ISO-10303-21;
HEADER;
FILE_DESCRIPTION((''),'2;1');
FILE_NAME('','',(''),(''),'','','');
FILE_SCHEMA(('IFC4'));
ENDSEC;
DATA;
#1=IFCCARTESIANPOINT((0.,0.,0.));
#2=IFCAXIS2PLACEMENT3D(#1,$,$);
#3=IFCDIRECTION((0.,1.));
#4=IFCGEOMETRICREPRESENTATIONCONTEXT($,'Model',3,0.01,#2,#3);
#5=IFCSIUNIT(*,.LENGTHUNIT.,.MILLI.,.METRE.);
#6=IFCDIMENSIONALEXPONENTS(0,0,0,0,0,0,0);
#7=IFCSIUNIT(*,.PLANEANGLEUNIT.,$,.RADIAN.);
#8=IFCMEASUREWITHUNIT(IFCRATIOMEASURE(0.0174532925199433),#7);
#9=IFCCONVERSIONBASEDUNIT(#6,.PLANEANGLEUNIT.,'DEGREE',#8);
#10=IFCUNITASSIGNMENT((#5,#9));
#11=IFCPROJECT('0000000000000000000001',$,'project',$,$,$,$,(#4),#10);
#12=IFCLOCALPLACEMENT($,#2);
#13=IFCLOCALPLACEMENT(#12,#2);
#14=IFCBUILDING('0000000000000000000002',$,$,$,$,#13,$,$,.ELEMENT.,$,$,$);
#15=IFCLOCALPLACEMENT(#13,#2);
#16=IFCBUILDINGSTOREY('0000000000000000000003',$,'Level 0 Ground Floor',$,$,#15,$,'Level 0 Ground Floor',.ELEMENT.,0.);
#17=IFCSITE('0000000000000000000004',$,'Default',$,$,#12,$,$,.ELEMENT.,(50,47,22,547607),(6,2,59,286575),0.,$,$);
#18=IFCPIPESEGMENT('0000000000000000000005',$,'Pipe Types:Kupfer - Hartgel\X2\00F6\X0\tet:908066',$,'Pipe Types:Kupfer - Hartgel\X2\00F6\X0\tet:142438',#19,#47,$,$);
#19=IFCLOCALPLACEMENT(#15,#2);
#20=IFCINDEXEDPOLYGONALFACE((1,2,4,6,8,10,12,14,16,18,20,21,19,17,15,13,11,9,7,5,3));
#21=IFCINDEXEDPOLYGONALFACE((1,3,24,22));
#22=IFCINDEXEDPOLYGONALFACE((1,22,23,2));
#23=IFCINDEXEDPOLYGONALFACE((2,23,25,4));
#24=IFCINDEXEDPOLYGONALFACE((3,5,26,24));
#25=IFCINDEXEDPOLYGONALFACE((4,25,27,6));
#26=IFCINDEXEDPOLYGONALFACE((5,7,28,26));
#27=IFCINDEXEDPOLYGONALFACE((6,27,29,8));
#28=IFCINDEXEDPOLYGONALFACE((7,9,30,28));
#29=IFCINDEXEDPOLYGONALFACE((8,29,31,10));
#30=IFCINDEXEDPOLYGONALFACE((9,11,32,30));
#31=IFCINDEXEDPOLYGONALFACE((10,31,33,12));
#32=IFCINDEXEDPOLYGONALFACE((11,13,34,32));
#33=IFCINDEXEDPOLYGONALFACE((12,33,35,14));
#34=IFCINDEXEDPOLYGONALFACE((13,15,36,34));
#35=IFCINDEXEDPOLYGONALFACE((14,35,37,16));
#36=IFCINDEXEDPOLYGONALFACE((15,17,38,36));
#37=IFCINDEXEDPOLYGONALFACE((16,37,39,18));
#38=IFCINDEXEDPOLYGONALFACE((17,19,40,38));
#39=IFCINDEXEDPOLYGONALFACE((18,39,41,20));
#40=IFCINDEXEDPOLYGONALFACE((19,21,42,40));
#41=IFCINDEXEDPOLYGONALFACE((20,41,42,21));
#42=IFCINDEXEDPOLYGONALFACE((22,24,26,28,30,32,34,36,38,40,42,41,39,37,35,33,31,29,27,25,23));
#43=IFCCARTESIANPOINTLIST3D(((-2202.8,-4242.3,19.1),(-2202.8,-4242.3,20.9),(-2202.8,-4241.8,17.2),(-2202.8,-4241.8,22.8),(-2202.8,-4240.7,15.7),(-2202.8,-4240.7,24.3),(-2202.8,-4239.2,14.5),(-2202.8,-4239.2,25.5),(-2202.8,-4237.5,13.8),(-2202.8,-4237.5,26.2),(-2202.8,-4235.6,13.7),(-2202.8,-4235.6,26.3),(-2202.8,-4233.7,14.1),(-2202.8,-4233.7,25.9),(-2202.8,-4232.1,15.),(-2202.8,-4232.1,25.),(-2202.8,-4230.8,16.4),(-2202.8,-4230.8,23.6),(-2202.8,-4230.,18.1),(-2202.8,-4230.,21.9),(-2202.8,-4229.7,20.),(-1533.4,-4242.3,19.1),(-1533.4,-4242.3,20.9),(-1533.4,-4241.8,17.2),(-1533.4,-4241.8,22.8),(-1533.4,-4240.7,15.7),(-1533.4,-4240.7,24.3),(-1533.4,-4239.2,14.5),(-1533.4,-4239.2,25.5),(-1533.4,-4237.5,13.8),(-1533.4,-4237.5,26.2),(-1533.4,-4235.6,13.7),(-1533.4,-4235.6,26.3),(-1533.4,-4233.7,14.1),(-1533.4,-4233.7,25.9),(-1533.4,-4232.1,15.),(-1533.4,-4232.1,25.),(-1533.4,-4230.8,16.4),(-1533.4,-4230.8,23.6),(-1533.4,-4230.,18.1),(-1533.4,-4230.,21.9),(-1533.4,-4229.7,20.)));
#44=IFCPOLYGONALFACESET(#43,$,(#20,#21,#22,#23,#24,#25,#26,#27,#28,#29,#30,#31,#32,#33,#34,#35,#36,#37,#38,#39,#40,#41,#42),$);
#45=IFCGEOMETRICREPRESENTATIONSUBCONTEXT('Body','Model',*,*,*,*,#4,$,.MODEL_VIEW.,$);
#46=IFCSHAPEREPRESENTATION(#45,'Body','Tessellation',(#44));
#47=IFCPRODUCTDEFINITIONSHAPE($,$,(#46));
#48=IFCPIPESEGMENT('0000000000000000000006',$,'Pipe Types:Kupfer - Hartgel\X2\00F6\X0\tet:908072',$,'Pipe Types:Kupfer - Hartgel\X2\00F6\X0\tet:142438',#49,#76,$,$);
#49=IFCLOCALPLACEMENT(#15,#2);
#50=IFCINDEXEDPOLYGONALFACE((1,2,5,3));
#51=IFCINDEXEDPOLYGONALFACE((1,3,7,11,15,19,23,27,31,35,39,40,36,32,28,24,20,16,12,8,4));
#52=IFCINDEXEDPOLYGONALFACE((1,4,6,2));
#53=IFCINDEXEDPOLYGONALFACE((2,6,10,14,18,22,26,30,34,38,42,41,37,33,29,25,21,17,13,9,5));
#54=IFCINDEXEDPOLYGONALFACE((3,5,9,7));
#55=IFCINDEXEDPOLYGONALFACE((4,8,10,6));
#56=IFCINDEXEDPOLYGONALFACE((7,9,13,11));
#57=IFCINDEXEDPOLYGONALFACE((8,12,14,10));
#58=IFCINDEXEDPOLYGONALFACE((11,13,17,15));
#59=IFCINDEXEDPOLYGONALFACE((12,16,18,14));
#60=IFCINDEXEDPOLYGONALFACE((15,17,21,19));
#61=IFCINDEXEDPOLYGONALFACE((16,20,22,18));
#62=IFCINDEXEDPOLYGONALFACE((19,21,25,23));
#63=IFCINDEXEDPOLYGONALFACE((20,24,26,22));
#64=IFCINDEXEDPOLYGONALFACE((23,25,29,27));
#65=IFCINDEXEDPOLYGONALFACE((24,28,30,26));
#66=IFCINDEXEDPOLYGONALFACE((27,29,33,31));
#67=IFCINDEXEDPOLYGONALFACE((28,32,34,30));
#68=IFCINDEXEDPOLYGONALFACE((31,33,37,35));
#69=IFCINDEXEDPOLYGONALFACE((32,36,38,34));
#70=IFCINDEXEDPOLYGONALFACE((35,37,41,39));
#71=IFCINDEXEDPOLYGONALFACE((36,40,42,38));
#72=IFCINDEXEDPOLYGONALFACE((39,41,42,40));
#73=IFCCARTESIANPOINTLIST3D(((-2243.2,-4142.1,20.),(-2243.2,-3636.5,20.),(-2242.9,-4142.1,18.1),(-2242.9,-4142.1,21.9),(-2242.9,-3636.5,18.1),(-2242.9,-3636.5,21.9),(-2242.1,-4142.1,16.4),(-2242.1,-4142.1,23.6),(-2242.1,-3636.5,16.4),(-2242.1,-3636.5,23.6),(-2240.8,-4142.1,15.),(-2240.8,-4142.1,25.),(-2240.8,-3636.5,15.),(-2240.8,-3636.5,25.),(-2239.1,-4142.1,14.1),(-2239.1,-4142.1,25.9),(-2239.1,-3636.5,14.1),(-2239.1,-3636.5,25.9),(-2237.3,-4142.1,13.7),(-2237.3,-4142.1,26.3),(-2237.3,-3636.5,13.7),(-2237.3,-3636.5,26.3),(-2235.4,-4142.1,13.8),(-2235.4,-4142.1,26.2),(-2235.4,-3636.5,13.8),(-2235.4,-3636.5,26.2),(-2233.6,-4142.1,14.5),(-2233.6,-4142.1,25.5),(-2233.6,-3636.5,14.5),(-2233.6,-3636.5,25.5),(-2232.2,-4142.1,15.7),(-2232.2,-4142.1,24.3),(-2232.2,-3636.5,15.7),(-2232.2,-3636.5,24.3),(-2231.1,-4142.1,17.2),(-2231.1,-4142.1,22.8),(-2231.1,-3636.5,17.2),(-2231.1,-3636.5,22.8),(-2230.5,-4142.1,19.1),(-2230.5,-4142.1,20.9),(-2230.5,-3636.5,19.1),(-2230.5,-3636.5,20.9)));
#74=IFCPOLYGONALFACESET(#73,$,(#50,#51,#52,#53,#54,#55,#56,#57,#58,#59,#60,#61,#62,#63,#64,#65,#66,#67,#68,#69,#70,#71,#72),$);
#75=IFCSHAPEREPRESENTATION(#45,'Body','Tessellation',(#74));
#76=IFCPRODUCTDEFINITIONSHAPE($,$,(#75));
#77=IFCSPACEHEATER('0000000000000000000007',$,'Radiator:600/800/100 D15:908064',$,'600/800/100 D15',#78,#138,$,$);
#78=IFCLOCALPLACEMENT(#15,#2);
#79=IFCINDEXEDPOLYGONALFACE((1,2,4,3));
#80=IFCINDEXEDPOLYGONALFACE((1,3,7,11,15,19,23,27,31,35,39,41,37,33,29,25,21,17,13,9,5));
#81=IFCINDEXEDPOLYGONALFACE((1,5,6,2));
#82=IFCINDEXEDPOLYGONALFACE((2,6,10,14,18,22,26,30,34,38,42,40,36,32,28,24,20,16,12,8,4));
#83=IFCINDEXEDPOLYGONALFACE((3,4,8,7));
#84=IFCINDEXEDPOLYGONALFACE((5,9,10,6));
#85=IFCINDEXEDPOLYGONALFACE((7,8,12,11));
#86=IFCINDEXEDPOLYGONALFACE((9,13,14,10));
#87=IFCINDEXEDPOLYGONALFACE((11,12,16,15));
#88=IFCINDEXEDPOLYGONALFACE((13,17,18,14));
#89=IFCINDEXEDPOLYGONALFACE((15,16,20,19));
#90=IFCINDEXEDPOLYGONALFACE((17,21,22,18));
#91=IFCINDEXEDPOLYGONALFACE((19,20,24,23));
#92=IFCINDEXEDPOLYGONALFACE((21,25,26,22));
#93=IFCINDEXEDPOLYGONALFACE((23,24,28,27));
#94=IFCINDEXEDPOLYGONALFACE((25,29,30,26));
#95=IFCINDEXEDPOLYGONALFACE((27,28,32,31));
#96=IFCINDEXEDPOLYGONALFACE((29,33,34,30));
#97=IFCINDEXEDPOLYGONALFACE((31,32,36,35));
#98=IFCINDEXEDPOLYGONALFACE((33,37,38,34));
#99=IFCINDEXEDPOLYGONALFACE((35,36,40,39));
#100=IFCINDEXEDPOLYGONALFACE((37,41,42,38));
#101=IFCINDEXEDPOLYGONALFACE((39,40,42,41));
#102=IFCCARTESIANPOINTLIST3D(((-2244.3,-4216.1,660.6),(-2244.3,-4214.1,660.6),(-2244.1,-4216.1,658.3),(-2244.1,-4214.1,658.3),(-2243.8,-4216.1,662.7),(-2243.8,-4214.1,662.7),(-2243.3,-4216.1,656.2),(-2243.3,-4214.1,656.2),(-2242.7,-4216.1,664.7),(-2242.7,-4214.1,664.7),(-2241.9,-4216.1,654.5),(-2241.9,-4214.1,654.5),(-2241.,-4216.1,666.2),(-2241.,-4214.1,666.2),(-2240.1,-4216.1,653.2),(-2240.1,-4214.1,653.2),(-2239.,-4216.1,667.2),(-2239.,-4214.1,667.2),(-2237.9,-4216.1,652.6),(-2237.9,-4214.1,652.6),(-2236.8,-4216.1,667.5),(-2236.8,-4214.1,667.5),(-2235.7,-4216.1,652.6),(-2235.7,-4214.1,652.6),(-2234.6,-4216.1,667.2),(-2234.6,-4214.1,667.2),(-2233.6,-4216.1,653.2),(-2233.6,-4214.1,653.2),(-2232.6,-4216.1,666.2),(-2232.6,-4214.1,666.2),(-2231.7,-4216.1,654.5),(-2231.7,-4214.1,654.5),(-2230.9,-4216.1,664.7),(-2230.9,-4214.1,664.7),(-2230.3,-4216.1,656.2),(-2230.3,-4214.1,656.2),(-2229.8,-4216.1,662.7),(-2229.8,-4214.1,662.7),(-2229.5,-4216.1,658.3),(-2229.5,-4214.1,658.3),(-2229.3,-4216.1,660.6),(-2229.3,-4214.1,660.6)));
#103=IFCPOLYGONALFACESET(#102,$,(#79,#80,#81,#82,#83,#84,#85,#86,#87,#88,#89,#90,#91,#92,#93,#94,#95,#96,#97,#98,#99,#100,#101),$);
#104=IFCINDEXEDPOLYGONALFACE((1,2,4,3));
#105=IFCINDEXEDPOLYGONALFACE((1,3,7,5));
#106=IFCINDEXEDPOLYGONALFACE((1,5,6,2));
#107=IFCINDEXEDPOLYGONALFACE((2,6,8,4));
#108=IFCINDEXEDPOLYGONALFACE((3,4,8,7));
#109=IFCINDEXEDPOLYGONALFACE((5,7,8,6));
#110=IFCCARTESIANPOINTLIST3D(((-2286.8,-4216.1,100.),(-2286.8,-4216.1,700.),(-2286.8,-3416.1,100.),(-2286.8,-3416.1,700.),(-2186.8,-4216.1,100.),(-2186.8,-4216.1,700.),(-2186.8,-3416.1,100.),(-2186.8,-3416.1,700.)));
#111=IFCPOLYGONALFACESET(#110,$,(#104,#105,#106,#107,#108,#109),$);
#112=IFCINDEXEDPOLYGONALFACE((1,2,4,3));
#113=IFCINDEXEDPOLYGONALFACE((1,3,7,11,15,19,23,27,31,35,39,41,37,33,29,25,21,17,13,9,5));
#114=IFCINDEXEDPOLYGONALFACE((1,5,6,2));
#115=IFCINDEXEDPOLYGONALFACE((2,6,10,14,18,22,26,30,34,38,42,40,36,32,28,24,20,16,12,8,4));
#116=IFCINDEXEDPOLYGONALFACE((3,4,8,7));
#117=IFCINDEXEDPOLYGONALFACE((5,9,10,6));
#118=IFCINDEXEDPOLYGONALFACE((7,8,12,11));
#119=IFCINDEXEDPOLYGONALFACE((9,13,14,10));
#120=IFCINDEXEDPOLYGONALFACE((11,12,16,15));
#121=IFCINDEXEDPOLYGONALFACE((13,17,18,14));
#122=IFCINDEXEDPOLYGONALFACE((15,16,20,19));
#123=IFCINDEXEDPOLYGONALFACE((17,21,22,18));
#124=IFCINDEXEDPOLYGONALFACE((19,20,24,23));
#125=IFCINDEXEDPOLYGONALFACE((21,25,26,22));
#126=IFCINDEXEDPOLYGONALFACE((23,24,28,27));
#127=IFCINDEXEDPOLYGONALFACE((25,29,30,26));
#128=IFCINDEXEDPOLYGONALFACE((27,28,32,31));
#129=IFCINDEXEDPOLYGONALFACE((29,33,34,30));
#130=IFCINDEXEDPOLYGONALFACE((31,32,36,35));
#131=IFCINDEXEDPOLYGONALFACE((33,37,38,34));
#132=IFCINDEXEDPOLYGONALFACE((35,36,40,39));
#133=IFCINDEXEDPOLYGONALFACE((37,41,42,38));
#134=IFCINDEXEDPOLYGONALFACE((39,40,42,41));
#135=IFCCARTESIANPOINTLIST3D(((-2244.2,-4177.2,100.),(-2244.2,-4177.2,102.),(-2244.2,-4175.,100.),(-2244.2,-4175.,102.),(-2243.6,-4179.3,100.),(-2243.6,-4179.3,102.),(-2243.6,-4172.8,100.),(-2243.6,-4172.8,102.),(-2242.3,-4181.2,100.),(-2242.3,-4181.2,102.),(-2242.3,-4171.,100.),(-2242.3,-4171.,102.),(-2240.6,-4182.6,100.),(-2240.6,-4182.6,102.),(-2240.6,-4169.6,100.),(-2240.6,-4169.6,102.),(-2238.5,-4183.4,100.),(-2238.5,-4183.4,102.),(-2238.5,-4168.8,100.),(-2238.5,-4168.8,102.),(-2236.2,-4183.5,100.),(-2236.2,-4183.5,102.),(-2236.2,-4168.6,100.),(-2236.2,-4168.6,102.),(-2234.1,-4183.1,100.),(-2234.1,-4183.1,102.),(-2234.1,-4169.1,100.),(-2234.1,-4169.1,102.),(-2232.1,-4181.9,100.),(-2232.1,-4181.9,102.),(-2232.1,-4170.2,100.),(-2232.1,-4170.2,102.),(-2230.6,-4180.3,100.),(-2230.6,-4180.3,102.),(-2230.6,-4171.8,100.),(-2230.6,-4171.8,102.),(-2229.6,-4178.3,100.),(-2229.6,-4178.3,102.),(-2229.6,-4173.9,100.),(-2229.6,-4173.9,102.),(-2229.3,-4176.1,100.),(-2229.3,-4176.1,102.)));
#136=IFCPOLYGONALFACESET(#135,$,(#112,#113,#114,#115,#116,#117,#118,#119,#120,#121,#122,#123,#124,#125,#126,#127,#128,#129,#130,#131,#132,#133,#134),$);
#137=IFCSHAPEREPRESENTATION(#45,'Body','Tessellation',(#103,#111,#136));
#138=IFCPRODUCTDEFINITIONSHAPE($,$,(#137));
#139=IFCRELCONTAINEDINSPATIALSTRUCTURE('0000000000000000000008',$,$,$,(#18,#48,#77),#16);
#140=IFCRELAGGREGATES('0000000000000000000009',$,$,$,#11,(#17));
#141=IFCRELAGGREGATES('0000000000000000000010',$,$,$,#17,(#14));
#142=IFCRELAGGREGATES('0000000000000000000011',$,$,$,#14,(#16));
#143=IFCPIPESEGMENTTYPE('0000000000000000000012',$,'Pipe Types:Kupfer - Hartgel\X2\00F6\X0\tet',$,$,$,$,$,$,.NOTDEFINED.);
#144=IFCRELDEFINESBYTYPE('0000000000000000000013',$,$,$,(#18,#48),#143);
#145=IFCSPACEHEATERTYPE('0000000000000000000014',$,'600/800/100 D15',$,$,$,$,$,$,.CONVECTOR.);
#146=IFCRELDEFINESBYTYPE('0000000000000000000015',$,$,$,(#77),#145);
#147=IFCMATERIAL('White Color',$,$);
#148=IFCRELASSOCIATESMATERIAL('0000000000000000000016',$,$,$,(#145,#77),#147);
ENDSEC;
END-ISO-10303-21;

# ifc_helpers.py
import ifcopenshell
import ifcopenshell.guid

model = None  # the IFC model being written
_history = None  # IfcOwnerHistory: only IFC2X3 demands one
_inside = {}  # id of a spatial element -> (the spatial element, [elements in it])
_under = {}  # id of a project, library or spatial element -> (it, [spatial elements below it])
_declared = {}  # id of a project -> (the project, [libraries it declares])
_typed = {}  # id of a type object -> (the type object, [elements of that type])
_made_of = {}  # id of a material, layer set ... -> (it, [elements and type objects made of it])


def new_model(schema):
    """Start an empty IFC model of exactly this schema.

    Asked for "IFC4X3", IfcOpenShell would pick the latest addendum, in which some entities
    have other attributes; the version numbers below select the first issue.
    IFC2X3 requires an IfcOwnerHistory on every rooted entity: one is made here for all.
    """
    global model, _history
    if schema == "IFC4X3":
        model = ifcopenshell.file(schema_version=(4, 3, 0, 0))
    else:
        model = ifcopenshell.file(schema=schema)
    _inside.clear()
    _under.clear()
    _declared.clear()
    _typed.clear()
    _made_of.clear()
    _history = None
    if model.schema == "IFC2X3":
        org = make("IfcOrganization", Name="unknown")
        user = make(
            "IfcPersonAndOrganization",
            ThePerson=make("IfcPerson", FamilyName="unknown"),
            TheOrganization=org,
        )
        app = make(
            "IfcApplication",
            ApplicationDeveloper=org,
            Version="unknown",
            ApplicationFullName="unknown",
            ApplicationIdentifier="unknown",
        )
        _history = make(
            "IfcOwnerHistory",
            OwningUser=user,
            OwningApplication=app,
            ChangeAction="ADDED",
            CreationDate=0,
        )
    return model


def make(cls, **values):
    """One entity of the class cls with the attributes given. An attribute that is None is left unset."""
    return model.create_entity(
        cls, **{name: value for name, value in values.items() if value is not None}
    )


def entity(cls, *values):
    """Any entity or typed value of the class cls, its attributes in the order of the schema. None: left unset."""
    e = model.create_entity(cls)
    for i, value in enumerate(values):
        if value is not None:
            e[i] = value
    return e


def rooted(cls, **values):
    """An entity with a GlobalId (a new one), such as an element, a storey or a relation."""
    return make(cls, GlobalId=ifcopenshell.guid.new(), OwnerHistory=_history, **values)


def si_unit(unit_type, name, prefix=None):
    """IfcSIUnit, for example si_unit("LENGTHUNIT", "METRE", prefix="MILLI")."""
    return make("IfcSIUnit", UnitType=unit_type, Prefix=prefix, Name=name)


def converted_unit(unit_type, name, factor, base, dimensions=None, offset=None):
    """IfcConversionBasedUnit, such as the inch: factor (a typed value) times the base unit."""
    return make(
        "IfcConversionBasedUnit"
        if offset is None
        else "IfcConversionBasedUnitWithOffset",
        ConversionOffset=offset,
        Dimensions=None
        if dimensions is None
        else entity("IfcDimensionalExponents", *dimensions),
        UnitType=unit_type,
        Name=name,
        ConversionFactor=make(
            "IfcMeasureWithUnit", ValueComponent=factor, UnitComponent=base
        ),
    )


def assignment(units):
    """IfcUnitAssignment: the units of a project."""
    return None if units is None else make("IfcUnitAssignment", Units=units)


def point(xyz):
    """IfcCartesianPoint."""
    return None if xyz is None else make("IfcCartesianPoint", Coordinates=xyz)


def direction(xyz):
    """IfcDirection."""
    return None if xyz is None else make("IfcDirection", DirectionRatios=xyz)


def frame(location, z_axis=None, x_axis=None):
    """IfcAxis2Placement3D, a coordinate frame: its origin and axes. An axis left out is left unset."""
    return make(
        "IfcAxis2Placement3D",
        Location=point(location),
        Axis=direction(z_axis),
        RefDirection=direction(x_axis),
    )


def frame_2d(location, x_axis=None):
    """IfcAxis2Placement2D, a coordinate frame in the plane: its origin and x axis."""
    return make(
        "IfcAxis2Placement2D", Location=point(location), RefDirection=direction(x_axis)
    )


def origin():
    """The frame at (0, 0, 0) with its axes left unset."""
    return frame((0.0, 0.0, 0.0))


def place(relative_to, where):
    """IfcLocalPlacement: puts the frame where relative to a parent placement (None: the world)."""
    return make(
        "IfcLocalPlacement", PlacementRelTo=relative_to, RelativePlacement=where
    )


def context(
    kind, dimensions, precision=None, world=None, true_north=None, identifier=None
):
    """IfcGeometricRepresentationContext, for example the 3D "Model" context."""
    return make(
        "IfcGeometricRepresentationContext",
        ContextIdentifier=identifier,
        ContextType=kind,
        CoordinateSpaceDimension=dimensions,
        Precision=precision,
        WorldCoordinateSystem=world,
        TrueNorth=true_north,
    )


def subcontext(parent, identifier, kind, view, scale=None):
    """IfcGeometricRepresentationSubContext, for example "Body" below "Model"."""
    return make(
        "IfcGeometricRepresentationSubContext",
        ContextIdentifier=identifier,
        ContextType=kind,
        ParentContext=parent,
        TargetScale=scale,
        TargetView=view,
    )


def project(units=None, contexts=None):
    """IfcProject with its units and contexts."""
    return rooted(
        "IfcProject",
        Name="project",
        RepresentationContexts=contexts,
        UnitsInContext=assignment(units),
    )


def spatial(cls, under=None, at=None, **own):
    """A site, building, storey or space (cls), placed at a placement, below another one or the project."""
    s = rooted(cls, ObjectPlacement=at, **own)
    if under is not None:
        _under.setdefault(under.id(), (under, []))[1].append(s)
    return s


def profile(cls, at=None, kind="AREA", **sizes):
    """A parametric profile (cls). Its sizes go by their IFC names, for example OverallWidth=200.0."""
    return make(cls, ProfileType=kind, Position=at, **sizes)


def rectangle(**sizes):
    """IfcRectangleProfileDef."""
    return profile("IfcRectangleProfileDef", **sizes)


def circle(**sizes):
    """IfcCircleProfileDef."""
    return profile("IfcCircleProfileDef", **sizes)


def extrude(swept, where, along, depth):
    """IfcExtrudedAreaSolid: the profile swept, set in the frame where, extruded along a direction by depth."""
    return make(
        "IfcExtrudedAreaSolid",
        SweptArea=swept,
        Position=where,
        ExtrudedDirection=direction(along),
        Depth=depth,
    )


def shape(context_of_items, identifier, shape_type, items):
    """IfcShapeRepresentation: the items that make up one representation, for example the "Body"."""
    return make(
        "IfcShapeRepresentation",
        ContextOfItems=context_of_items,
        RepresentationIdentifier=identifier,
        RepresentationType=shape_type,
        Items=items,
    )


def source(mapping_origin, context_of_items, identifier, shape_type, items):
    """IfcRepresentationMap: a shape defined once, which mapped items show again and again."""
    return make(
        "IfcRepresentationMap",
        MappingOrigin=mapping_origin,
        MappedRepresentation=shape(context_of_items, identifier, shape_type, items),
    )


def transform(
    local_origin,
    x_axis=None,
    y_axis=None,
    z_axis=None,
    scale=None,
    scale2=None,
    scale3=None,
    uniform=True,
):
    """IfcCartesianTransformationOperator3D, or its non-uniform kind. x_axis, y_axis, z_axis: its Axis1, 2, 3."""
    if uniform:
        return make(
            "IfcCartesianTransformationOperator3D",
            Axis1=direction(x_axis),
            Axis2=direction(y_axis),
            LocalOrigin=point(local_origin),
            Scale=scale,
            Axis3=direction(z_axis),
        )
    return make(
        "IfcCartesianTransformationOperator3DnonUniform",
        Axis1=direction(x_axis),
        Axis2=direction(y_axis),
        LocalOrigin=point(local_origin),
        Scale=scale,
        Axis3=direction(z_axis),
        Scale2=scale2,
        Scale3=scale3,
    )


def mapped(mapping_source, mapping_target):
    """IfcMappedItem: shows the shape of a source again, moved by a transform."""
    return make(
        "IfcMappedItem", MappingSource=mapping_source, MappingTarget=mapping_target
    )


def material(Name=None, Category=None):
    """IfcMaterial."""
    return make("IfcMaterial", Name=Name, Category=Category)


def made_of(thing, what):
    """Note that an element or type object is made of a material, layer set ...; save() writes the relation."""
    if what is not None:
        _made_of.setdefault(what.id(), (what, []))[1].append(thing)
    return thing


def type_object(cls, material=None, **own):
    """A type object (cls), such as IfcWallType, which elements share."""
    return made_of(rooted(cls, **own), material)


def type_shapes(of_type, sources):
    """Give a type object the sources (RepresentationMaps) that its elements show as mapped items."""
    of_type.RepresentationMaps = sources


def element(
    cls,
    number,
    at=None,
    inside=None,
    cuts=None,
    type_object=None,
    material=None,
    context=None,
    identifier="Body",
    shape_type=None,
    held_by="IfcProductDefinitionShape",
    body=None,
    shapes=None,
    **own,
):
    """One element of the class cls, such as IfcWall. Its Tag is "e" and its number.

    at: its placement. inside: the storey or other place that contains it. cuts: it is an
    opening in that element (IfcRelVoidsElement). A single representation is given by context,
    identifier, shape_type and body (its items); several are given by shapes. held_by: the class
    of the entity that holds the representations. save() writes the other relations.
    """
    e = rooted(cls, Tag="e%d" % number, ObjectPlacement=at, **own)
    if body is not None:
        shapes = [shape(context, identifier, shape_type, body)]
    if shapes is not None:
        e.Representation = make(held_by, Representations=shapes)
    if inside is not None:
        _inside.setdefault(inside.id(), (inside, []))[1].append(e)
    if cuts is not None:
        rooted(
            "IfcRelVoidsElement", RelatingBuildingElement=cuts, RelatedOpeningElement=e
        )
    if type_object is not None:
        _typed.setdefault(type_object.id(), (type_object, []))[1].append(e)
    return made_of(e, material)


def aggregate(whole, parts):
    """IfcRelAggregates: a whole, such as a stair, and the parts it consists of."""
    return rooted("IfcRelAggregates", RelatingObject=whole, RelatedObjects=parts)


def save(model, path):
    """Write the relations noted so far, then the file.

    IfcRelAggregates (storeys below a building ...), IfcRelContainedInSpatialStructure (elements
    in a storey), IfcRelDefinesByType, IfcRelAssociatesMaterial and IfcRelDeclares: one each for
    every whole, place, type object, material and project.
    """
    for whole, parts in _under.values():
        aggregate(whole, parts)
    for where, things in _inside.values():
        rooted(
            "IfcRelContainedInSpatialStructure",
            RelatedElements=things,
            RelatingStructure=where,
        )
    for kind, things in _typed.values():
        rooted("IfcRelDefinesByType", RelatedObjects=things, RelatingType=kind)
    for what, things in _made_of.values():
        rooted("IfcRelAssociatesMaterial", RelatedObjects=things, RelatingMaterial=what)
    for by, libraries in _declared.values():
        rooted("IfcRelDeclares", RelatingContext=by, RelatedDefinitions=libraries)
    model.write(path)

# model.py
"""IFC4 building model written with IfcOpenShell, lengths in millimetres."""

from ifc_helpers import new_model, entity, si_unit, converted_unit, direction, frame, frame_2d, origin, place, context, subcontext, project, spatial, rectangle, circle, extrude, source, transform, mapped, material, type_object, type_shapes, element, save


model = new_model("IFC4")

# Units and contexts
model_context = context("Model", 3, precision=0.01, world=origin(), true_north=direction((0.0, 1.0)))
body_context = subcontext(model_context, "Body", "Model", "MODEL_VIEW")
ifc_project = project(units=[si_unit("LENGTHUNIT", "METRE", prefix="MILLI"), converted_unit("PLANEANGLEUNIT", "DEGREE", entity("IfcRatioMeasure", 0.0174532925199433), si_unit("PLANEANGLEUNIT", "RADIAN"), dimensions=[0, 0, 0, 0, 0, 0, 0])], contexts=[model_context])

# Site, building, storey
site_placement = place(None, origin())
site = spatial("IfcSite", under=ifc_project, at=site_placement, Name="Default", CompositionType="ELEMENT", RefLatitude=(50, 47, 22, 547607), RefLongitude=(6, 2, 59, 286575), RefElevation=0.0)
building_placement = place(site_placement, origin())
building = spatial("IfcBuilding", under=site, at=building_placement, CompositionType="ELEMENT")
storey_placement = place(building_placement, origin())
storey = spatial("IfcBuildingStorey", under=building, at=storey_placement, Name="Level 0 Ground Floor", LongName="Level 0 Ground Floor", CompositionType="ELEMENT", Elevation=0.0)

# Pipe segments
pipe_segment_type = type_object("IfcPipeSegmentType", Name="Pipe Types:Kupfer - Hartgelötet", PredefinedType="NOTDEFINED")
pipe_segment_1_placement = place(storey_placement, frame((-2202.8, -4244.0, 12.1)))
element("IfcPipeSegment", 1, at=pipe_segment_1_placement, inside=storey, type_object=pipe_segment_type, Name="Pipe Types:Kupfer - Hartgelötet:908066", ObjectType="Pipe Types:Kupfer - Hartgelötet:142438", context=body_context, shape_type="SweptSolid", body=[
    extrude(circle(Radius=6.3, at=frame_2d((0.0, 0.0), x_axis=(1.0, 0.0))), frame((0.0, 7.9, 7.9), z_axis=(1.0, 0.000044, 0.0), x_axis=(-0.000044, 1.0, 0.0)), (0.0, 0.0, 1.0), 669.4),
])
pipe_segment_2_placement = place(storey_placement, frame((-2244.8, -4142.1, 12.1)))
element("IfcPipeSegment", 2, at=pipe_segment_2_placement, inside=storey, type_object=pipe_segment_type, Name="Pipe Types:Kupfer - Hartgelötet:908072", ObjectType="Pipe Types:Kupfer - Hartgelötet:142438", context=body_context, shape_type="SweptSolid", body=[
    extrude(circle(Radius=6.3, at=frame_2d((0.0, 0.0), x_axis=(1.0, 0.0))), frame((7.9, 0.0, 7.9), z_axis=(0.0, 1.0, 0.0), x_axis=(-1.0, 0.0, 0.0)), (0.0, 0.0, 1.0), 505.5),
])

# Space heater
ifc_material = material(Name="White Color")
space_heater_type = type_object("IfcSpaceHeaterType", Name="600/800/100 D15", PredefinedType="CONVECTOR", material=ifc_material)
shared_shape_1 = source(origin(), body_context, "Body", "SweptSolid", [
    extrude(circle(Radius=7.5, at=frame_2d((0.0, 0.0), x_axis=(1.0, 0.0))), frame((798.0, 50.0, 560.0), z_axis=(1.0, 0.0, 0.0), x_axis=(0.0, 0.0, 1.0)), (0.0, 0.0, 1.0), 2.0),
    extrude(rectangle(XDim=100.0, YDim=800.0, at=frame_2d((0.0, 0.0), x_axis=(1.0, 0.0))), frame((400.0, 50.0, 0.0), z_axis=(0.0, 0.0, 1.0), x_axis=(0.0, 1.0, 0.0)), (0.0, 0.0, 1.0), 600.0),
    extrude(circle(Radius=7.5, at=frame_2d((0.0, 0.0), x_axis=(1.0, 0.0))), frame((760.0, 50.0, 0.0), z_axis=(0.0, 0.0, 1.0), x_axis=(0.0, 1.0, 0.0)), (0.0, 0.0, 1.0), 2.0),
])
type_shapes(space_heater_type, [shared_shape_1])
space_heater_placement = place(storey_placement, frame((-2286.8, -3416.1, 100.0), z_axis=(0.0, 0.0, 1.0), x_axis=(0.000017, -1.0, 0.0)))
element("IfcSpaceHeater", 3, at=space_heater_placement, inside=storey, type_object=space_heater_type, material=ifc_material, Name="Radiator:600/800/100 D15:908064", ObjectType="600/800/100 D15", context=body_context, shape_type="MappedRepresentation", body=[
    mapped(shared_shape_1, transform((0.0, 0.0, 0.0), scale=1.0)),
])

save(model, "model.ifc")
